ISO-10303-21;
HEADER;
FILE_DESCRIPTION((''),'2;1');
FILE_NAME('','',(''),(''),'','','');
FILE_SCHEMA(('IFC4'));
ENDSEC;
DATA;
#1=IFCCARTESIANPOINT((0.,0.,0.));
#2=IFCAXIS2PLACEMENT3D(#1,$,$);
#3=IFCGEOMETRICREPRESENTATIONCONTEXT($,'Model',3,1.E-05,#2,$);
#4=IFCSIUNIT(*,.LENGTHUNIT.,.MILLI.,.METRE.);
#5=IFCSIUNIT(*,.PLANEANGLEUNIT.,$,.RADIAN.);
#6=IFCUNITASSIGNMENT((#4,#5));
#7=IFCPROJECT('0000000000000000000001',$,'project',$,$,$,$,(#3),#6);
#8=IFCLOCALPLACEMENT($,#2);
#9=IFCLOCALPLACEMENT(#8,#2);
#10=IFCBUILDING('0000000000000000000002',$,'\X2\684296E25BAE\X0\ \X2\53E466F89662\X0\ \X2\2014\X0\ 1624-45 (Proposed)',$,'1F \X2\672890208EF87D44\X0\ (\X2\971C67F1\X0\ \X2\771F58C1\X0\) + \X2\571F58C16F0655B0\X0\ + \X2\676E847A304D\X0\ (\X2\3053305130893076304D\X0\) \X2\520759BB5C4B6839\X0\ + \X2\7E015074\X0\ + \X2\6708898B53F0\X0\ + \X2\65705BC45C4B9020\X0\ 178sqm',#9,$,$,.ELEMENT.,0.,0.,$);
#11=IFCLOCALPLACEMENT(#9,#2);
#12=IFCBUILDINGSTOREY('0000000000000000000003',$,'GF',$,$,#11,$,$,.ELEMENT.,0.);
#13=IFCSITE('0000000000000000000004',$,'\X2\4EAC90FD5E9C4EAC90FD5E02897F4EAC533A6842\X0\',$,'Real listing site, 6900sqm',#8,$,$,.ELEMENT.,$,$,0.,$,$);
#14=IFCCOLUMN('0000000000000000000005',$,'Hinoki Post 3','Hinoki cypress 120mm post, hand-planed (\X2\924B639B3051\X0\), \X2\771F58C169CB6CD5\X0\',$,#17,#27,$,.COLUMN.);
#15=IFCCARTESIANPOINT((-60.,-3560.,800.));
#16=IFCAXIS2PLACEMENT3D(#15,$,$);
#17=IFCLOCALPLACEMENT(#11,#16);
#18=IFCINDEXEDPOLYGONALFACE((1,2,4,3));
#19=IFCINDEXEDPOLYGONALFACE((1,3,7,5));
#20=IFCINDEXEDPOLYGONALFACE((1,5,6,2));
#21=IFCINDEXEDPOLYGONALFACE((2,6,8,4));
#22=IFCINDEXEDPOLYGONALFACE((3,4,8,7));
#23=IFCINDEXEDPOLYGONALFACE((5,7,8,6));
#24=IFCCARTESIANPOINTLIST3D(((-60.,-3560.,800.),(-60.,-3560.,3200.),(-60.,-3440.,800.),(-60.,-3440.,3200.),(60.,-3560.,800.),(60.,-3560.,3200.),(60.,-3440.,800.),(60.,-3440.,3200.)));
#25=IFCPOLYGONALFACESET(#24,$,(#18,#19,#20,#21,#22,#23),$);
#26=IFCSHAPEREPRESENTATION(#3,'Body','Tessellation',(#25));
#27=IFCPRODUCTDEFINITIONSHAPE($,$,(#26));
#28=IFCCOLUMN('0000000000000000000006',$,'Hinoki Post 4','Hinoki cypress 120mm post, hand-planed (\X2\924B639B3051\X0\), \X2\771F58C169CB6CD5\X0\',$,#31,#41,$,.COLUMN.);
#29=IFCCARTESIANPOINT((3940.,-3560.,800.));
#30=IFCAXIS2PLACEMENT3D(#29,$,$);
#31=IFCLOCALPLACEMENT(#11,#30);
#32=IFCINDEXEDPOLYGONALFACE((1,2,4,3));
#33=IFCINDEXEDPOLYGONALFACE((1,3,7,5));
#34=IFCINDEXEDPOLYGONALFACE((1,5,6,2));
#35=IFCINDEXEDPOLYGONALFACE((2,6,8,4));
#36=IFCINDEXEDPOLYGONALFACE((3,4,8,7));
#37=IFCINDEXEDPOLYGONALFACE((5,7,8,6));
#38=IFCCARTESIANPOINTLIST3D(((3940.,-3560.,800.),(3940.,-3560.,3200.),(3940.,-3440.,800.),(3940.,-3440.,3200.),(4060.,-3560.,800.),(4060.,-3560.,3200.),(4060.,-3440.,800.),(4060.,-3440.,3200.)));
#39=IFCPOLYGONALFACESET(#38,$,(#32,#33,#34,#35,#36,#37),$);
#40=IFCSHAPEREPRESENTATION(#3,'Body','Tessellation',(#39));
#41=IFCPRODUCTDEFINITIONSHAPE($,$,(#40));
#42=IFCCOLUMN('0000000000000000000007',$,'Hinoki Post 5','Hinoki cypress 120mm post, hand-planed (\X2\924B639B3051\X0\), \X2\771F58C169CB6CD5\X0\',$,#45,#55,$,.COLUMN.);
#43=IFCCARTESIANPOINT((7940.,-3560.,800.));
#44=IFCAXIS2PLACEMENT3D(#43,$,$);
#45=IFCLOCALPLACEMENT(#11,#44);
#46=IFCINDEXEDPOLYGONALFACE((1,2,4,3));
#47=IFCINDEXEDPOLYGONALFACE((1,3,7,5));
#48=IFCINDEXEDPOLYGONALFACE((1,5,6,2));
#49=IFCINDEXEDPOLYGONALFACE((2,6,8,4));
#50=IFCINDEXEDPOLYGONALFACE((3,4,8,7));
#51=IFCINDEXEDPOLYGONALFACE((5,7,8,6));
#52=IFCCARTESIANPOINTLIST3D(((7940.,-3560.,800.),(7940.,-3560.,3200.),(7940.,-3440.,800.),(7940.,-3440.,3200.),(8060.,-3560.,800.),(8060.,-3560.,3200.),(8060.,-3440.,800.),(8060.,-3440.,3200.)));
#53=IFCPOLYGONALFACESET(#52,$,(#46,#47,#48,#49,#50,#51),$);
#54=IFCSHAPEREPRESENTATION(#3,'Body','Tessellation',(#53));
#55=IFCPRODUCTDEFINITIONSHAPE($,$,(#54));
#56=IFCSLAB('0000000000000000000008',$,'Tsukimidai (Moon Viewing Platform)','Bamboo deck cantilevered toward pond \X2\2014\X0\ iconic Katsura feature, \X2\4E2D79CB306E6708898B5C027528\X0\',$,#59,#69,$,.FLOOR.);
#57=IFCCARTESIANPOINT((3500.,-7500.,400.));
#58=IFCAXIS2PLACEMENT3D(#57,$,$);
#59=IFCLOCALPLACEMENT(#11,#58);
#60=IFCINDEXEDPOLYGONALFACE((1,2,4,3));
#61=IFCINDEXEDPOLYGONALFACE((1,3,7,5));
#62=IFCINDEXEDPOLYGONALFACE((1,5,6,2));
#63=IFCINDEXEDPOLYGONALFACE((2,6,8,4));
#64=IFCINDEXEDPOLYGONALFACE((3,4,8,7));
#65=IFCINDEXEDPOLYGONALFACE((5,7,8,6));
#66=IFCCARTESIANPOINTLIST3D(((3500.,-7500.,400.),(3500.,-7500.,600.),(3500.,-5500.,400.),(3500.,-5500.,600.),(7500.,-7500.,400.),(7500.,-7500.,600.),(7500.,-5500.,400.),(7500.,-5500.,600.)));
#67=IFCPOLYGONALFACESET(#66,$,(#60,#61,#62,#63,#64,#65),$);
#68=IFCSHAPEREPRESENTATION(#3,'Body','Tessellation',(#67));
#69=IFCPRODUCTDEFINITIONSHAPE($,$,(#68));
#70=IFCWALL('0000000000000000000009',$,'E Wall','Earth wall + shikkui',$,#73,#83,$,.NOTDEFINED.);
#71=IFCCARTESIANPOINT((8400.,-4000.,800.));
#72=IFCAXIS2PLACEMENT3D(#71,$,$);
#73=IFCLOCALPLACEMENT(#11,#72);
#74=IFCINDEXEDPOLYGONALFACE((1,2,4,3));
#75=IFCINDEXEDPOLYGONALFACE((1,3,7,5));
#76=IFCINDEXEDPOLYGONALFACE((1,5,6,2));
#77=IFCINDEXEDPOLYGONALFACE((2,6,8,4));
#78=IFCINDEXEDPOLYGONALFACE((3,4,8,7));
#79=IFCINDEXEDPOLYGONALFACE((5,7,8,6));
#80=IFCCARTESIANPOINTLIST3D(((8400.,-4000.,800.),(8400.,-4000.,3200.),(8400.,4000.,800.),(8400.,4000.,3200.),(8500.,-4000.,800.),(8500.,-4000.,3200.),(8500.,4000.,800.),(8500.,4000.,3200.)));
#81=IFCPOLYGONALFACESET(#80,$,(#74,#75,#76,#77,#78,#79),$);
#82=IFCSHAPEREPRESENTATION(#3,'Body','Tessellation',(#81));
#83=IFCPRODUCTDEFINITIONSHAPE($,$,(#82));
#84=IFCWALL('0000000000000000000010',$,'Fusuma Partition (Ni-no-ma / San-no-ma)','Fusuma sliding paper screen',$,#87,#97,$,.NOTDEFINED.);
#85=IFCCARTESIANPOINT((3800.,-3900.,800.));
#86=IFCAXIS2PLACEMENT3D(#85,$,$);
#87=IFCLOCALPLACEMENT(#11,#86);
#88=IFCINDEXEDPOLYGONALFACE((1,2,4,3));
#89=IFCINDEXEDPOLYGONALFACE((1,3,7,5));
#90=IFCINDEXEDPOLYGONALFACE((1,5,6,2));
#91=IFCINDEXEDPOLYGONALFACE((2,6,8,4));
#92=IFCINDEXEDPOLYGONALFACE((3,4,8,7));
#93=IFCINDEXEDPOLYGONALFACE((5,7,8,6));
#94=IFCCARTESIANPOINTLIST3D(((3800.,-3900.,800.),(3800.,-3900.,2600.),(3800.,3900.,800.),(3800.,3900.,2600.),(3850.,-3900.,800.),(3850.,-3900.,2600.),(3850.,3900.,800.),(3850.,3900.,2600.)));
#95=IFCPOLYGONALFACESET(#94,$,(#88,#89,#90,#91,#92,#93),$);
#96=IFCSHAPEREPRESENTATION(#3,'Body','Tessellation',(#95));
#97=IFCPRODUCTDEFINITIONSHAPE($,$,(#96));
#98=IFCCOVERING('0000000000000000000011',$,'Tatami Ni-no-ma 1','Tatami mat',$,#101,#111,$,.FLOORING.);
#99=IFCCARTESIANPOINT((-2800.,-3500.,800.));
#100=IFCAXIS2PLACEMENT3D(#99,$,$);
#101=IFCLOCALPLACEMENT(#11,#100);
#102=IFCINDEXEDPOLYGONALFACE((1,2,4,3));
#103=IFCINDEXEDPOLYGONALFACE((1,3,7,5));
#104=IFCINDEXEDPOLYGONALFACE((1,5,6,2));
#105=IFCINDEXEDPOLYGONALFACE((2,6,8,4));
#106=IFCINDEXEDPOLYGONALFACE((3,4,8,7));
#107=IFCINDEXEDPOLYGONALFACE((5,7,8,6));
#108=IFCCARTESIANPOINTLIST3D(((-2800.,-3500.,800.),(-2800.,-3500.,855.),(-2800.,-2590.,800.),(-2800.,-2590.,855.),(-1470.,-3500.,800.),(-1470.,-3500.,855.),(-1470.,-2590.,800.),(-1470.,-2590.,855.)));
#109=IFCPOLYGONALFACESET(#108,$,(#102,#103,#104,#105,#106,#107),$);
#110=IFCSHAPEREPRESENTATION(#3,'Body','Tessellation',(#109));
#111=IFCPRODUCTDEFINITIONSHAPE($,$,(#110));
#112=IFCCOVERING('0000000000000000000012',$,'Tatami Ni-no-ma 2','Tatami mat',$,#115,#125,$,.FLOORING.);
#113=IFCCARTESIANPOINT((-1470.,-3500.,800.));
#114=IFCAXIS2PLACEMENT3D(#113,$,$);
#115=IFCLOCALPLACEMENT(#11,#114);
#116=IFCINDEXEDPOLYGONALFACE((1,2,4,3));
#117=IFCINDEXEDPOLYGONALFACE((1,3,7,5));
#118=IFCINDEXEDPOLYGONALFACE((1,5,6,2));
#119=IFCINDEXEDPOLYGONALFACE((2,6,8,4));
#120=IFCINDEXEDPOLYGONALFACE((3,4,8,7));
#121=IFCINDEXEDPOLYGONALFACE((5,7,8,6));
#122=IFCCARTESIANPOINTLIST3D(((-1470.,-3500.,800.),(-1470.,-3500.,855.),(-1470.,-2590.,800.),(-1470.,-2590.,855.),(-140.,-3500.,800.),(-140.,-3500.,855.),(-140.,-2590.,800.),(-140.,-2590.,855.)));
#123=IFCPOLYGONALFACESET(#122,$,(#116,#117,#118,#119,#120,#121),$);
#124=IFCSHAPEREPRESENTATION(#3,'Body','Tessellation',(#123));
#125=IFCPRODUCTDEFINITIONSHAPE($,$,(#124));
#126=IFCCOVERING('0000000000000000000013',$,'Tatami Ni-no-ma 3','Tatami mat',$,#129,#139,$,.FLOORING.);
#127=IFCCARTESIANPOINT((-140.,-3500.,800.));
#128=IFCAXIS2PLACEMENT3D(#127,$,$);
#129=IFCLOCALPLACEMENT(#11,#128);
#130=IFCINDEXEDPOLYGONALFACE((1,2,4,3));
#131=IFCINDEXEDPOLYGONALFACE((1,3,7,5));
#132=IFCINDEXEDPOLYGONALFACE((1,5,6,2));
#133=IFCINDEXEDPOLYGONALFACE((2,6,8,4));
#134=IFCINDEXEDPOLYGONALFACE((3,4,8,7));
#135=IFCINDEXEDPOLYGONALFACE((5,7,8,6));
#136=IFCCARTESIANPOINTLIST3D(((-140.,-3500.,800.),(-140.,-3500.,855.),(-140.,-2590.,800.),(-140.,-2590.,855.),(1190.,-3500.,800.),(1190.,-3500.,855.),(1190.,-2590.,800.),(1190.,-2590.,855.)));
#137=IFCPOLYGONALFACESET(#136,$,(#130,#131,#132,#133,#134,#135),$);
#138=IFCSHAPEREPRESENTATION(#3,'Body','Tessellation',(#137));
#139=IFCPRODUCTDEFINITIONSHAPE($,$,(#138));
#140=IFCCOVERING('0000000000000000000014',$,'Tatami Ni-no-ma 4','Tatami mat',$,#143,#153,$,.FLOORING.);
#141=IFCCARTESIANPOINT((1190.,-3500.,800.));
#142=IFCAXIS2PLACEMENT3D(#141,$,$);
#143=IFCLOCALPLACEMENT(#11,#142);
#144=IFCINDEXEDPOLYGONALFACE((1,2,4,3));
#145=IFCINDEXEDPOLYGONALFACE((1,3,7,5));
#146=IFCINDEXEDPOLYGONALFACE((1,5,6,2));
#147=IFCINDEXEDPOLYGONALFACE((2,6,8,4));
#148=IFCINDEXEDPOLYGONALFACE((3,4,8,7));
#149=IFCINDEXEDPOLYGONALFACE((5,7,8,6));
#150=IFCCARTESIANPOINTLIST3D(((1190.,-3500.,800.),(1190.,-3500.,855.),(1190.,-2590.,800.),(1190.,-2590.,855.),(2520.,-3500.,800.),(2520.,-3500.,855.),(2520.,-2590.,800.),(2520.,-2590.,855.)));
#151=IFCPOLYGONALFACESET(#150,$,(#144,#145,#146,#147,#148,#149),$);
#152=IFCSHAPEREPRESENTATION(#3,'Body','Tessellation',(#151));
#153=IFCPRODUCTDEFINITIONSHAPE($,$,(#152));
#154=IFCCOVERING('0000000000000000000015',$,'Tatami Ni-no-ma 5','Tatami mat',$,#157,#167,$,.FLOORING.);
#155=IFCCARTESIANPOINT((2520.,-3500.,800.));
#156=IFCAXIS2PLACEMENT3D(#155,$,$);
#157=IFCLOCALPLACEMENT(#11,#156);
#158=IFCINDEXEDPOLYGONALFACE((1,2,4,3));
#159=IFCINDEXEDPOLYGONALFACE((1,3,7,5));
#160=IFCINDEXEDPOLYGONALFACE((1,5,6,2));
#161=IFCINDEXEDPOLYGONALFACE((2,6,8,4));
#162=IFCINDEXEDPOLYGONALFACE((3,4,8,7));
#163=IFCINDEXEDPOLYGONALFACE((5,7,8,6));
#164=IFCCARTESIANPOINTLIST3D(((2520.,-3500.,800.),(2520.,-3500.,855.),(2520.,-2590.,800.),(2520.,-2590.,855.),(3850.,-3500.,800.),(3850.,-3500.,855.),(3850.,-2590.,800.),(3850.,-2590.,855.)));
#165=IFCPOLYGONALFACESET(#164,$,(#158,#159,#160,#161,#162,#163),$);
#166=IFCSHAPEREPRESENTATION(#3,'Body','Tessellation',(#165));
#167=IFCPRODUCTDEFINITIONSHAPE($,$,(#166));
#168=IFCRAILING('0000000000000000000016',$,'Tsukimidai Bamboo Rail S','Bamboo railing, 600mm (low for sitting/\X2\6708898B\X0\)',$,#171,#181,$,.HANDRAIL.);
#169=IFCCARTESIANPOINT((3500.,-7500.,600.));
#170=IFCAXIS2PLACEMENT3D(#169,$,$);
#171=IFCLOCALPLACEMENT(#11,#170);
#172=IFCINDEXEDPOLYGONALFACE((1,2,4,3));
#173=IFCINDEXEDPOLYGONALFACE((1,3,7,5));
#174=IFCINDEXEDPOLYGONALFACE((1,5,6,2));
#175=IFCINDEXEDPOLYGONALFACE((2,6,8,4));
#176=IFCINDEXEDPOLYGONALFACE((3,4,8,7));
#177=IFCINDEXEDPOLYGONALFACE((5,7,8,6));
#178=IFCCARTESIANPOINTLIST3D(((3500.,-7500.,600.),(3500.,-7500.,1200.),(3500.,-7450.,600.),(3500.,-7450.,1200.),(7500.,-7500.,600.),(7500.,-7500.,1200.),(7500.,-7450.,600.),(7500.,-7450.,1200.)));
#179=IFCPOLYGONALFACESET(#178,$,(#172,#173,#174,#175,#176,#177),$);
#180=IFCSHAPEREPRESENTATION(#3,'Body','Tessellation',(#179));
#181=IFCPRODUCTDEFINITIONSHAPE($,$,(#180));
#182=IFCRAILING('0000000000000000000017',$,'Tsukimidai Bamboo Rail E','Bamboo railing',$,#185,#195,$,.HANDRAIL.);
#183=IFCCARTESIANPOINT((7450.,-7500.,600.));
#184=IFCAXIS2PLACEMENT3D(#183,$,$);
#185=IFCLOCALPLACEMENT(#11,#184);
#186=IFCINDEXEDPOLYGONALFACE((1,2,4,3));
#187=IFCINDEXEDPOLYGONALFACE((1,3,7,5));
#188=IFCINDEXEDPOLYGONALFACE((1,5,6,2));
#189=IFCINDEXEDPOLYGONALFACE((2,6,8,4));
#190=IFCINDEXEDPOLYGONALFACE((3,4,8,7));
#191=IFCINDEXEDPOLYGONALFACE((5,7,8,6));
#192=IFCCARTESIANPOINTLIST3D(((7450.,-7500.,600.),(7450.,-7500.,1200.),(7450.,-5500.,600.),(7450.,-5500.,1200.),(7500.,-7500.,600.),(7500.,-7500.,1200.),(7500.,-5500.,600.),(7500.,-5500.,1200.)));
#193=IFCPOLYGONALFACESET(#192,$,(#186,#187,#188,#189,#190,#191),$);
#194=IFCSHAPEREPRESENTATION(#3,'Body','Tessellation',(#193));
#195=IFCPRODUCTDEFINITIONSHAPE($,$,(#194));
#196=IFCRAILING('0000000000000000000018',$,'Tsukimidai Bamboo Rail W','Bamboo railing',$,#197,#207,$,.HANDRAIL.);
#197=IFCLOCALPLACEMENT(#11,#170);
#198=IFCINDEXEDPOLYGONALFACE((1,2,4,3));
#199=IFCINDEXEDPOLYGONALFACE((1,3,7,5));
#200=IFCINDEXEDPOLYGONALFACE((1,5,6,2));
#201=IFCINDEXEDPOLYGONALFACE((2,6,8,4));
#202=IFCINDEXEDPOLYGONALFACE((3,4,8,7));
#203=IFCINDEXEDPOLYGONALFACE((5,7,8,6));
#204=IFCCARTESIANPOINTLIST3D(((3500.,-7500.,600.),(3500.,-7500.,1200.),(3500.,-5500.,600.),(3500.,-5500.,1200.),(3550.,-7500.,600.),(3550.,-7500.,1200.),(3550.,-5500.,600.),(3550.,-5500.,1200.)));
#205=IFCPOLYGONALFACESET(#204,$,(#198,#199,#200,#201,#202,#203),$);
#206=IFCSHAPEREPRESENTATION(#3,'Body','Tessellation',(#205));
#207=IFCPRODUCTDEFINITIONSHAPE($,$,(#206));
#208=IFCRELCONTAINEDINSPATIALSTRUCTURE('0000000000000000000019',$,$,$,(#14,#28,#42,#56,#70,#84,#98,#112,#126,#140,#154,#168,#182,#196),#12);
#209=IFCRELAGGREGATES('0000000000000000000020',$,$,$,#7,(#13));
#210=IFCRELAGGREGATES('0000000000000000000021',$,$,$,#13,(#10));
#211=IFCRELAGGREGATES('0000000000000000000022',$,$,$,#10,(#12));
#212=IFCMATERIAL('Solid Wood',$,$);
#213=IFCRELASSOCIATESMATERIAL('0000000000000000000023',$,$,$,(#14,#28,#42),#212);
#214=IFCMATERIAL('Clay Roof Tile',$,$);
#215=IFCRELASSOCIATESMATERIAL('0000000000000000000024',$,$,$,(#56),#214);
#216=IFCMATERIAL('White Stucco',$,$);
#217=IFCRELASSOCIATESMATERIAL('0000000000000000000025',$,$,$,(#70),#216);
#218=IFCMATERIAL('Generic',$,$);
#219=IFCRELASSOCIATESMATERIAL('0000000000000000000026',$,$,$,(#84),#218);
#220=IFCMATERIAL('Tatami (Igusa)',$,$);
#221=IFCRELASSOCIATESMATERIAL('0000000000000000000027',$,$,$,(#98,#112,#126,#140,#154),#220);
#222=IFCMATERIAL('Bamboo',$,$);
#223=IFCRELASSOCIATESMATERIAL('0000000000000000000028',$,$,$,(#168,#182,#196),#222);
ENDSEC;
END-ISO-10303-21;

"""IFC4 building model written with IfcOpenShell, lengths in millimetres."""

from ifc_helpers import new_model, si_unit, frame, frame_2d, origin, place, context, project, spatial, rectangle, extrude, material, element, save


model = new_model("IFC4")

# Units and contexts
model_context = context("Model", 3, precision=1e-05, world=origin())
ifc_project = project(units=[si_unit("LENGTHUNIT", "METRE", prefix="MILLI"), si_unit("PLANEANGLEUNIT", "RADIAN")], contexts=[model_context])

# Site, building, storey
site_placement = place(None, origin())
site = spatial("IfcSite", under=ifc_project, at=site_placement, Name="京都府京都市西京区桂", ObjectType="Real listing site, 6900sqm", CompositionType="ELEMENT", RefElevation=0.0)
building_placement = place(site_placement, origin())
building = spatial("IfcBuilding", under=site, at=building_placement, Name="桂離宮 古書院 — 1624-45 (Proposed)", ObjectType="1F 木造軸組 (霜柱 真壁) + 土壁漆喰 + 杮葺き (こけらぶき) 切妻屋根 + 縁側 + 月見台 + 数寄屋造 178sqm", CompositionType="ELEMENT", ElevationOfRefHeight=0.0, ElevationOfTerrain=0.0)
storey_placement = place(building_placement, origin())
storey = spatial("IfcBuildingStorey", under=building, at=storey_placement, Name="GF", CompositionType="ELEMENT", Elevation=0.0)

# Columns
ifc_material_1 = material(Name="Solid Wood")
column_1_placement = place(storey_placement, frame((-60.0, -3560.0, 800.0)))
element("IfcColumn", 1, at=column_1_placement, inside=storey, material=ifc_material_1, Name="Hinoki Post 3", Description="Hinoki cypress 120mm post, hand-planed (鉋掛け), 真壁構法", PredefinedType="COLUMN", context=model_context, shape_type="SweptSolid", body=[
    extrude(rectangle(XDim=120.0, YDim=120.0, at=frame_2d((60.0, 60.0))), frame((-60.0, -3560.0, 800.0)), (0.0, 0.0, 1.0), 2400.0),
])
column_2_placement = place(storey_placement, frame((3940.0, -3560.0, 800.0)))
element("IfcColumn", 2, at=column_2_placement, inside=storey, material=ifc_material_1, Name="Hinoki Post 4", Description="Hinoki cypress 120mm post, hand-planed (鉋掛け), 真壁構法", PredefinedType="COLUMN", context=model_context, shape_type="SweptSolid", body=[
    extrude(rectangle(XDim=120.0, YDim=120.0, at=frame_2d((60.0, 60.0))), frame((3940.0, -3560.0, 800.0)), (0.0, 0.0, 1.0), 2400.0),
])
column_3_placement = place(storey_placement, frame((7940.0, -3560.0, 800.0)))
element("IfcColumn", 3, at=column_3_placement, inside=storey, material=ifc_material_1, Name="Hinoki Post 5", Description="Hinoki cypress 120mm post, hand-planed (鉋掛け), 真壁構法", PredefinedType="COLUMN", context=model_context, shape_type="SweptSolid", body=[
    extrude(rectangle(XDim=120.0, YDim=120.0, at=frame_2d((60.0, 60.0))), frame((7940.0, -3560.0, 800.0)), (0.0, 0.0, 1.0), 2400.0),
])

# Slab
ifc_material_2 = material(Name="Clay Roof Tile")
slab_placement = place(storey_placement, frame((3500.0, -7500.0, 400.0)))
element("IfcSlab", 4, at=slab_placement, inside=storey, material=ifc_material_2, Name="Tsukimidai (Moon Viewing Platform)", Description="Bamboo deck cantilevered toward pond — iconic Katsura feature, 中秋の月見専用", PredefinedType="FLOOR", context=model_context, shape_type="SweptSolid", body=[
    extrude(rectangle(XDim=4000.0, YDim=2000.0, at=frame_2d((2000.0, 1000.0))), frame((3500.0, -7500.0, 400.0)), (0.0, 0.0, 1.0), 200.0),
])

# Walls
ifc_material_3 = material(Name="White Stucco")
wall_1_placement = place(storey_placement, frame((8400.0, -4000.0, 800.0)))
element("IfcWall", 5, at=wall_1_placement, inside=storey, material=ifc_material_3, Name="E Wall", Description="Earth wall + shikkui", PredefinedType="NOTDEFINED", context=model_context, shape_type="SweptSolid", body=[
    extrude(rectangle(XDim=100.0, YDim=8000.0, at=frame_2d((50.0, 4000.0))), frame((8400.0, -4000.0, 800.0)), (0.0, 0.0, 1.0), 2400.0),
])
ifc_material_4 = material(Name="Generic")
wall_2_placement = place(storey_placement, frame((3800.0, -3900.0, 800.0)))
element("IfcWall", 6, at=wall_2_placement, inside=storey, material=ifc_material_4, Name="Fusuma Partition (Ni-no-ma / San-no-ma)", Description="Fusuma sliding paper screen", PredefinedType="NOTDEFINED", context=model_context, shape_type="SweptSolid", body=[
    extrude(rectangle(XDim=50.0, YDim=7800.0, at=frame_2d((25.0, 3900.0))), frame((3800.0, -3900.0, 800.0)), (0.0, 0.0, 1.0), 1800.0),
])

# Coverings
ifc_material_5 = material(Name="Tatami (Igusa)")
covering_1_placement = place(storey_placement, frame((-2800.0, -3500.0, 800.0)))
element("IfcCovering", 7, at=covering_1_placement, inside=storey, material=ifc_material_5, Name="Tatami Ni-no-ma 1", Description="Tatami mat", PredefinedType="FLOORING", context=model_context, shape_type="SweptSolid", body=[
    extrude(rectangle(XDim=1330.0, YDim=910.0, at=frame_2d((665.0, 455.0))), frame((-2800.0, -3500.0, 800.0)), (0.0, 0.0, 1.0), 55.0),
])
covering_2_placement = place(storey_placement, frame((-1470.0, -3500.0, 800.0)))
element("IfcCovering", 8, at=covering_2_placement, inside=storey, material=ifc_material_5, Name="Tatami Ni-no-ma 2", Description="Tatami mat", PredefinedType="FLOORING", context=model_context, shape_type="SweptSolid", body=[
    extrude(rectangle(XDim=1330.0, YDim=910.0, at=frame_2d((665.0, 455.0))), frame((-1470.0, -3500.0, 800.0)), (0.0, 0.0, 1.0), 55.0),
])
covering_3_placement = place(storey_placement, frame((-140.0, -3500.0, 800.0)))
element("IfcCovering", 9, at=covering_3_placement, inside=storey, material=ifc_material_5, Name="Tatami Ni-no-ma 3", Description="Tatami mat", PredefinedType="FLOORING", context=model_context, shape_type="SweptSolid", body=[
    extrude(rectangle(XDim=1330.0, YDim=910.0, at=frame_2d((665.0, 455.0))), frame((-140.0, -3500.0, 800.0)), (0.0, 0.0, 1.0), 55.0),
])
covering_4_placement = place(storey_placement, frame((1190.0, -3500.0, 800.0)))
element("IfcCovering", 10, at=covering_4_placement, inside=storey, material=ifc_material_5, Name="Tatami Ni-no-ma 4", Description="Tatami mat", PredefinedType="FLOORING", context=model_context, shape_type="SweptSolid", body=[
    extrude(rectangle(XDim=1330.0, YDim=910.0, at=frame_2d((665.0, 455.0))), frame((1190.0, -3500.0, 800.0)), (0.0, 0.0, 1.0), 55.0),
])
covering_5_placement = place(storey_placement, frame((2520.0, -3500.0, 800.0)))
element("IfcCovering", 11, at=covering_5_placement, inside=storey, material=ifc_material_5, Name="Tatami Ni-no-ma 5", Description="Tatami mat", PredefinedType="FLOORING", context=model_context, shape_type="SweptSolid", body=[
    extrude(rectangle(XDim=1330.0, YDim=910.0, at=frame_2d((665.0, 455.0))), frame((2520.0, -3500.0, 800.0)), (0.0, 0.0, 1.0), 55.0),
])

# Railings
ifc_material_6 = material(Name="Bamboo")
railing_1_placement = place(storey_placement, frame((3500.0, -7500.0, 600.0)))
element("IfcRailing", 12, at=railing_1_placement, inside=storey, material=ifc_material_6, Name="Tsukimidai Bamboo Rail S", Description="Bamboo railing, 600mm (low for sitting/月見)", PredefinedType="HANDRAIL", context=model_context, shape_type="SweptSolid", body=[
    extrude(rectangle(XDim=4000.0, YDim=50.0, at=frame_2d((2000.0, 25.0))), frame((3500.0, -7500.0, 600.0)), (0.0, 0.0, 1.0), 600.0),
])
railing_2_placement = place(storey_placement, frame((7450.0, -7500.0, 600.0)))
element("IfcRailing", 13, at=railing_2_placement, inside=storey, material=ifc_material_6, Name="Tsukimidai Bamboo Rail E", Description="Bamboo railing", PredefinedType="HANDRAIL", context=model_context, shape_type="SweptSolid", body=[
    extrude(rectangle(XDim=50.0, YDim=2000.0, at=frame_2d((25.0, 1000.0))), frame((7450.0, -7500.0, 600.0)), (0.0, 0.0, 1.0), 600.0),
])
railing_3_placement = place(storey_placement, frame((3500.0, -7500.0, 600.0)))
element("IfcRailing", 14, at=railing_3_placement, inside=storey, material=ifc_material_6, Name="Tsukimidai Bamboo Rail W", Description="Bamboo railing", PredefinedType="HANDRAIL", context=model_context, shape_type="SweptSolid", body=[
    extrude(rectangle(XDim=50.0, YDim=2000.0, at=frame_2d((25.0, 1000.0))), frame((3500.0, -7500.0, 600.0)), (0.0, 0.0, 1.0), 600.0),
])

save(model, "model.ifc")
